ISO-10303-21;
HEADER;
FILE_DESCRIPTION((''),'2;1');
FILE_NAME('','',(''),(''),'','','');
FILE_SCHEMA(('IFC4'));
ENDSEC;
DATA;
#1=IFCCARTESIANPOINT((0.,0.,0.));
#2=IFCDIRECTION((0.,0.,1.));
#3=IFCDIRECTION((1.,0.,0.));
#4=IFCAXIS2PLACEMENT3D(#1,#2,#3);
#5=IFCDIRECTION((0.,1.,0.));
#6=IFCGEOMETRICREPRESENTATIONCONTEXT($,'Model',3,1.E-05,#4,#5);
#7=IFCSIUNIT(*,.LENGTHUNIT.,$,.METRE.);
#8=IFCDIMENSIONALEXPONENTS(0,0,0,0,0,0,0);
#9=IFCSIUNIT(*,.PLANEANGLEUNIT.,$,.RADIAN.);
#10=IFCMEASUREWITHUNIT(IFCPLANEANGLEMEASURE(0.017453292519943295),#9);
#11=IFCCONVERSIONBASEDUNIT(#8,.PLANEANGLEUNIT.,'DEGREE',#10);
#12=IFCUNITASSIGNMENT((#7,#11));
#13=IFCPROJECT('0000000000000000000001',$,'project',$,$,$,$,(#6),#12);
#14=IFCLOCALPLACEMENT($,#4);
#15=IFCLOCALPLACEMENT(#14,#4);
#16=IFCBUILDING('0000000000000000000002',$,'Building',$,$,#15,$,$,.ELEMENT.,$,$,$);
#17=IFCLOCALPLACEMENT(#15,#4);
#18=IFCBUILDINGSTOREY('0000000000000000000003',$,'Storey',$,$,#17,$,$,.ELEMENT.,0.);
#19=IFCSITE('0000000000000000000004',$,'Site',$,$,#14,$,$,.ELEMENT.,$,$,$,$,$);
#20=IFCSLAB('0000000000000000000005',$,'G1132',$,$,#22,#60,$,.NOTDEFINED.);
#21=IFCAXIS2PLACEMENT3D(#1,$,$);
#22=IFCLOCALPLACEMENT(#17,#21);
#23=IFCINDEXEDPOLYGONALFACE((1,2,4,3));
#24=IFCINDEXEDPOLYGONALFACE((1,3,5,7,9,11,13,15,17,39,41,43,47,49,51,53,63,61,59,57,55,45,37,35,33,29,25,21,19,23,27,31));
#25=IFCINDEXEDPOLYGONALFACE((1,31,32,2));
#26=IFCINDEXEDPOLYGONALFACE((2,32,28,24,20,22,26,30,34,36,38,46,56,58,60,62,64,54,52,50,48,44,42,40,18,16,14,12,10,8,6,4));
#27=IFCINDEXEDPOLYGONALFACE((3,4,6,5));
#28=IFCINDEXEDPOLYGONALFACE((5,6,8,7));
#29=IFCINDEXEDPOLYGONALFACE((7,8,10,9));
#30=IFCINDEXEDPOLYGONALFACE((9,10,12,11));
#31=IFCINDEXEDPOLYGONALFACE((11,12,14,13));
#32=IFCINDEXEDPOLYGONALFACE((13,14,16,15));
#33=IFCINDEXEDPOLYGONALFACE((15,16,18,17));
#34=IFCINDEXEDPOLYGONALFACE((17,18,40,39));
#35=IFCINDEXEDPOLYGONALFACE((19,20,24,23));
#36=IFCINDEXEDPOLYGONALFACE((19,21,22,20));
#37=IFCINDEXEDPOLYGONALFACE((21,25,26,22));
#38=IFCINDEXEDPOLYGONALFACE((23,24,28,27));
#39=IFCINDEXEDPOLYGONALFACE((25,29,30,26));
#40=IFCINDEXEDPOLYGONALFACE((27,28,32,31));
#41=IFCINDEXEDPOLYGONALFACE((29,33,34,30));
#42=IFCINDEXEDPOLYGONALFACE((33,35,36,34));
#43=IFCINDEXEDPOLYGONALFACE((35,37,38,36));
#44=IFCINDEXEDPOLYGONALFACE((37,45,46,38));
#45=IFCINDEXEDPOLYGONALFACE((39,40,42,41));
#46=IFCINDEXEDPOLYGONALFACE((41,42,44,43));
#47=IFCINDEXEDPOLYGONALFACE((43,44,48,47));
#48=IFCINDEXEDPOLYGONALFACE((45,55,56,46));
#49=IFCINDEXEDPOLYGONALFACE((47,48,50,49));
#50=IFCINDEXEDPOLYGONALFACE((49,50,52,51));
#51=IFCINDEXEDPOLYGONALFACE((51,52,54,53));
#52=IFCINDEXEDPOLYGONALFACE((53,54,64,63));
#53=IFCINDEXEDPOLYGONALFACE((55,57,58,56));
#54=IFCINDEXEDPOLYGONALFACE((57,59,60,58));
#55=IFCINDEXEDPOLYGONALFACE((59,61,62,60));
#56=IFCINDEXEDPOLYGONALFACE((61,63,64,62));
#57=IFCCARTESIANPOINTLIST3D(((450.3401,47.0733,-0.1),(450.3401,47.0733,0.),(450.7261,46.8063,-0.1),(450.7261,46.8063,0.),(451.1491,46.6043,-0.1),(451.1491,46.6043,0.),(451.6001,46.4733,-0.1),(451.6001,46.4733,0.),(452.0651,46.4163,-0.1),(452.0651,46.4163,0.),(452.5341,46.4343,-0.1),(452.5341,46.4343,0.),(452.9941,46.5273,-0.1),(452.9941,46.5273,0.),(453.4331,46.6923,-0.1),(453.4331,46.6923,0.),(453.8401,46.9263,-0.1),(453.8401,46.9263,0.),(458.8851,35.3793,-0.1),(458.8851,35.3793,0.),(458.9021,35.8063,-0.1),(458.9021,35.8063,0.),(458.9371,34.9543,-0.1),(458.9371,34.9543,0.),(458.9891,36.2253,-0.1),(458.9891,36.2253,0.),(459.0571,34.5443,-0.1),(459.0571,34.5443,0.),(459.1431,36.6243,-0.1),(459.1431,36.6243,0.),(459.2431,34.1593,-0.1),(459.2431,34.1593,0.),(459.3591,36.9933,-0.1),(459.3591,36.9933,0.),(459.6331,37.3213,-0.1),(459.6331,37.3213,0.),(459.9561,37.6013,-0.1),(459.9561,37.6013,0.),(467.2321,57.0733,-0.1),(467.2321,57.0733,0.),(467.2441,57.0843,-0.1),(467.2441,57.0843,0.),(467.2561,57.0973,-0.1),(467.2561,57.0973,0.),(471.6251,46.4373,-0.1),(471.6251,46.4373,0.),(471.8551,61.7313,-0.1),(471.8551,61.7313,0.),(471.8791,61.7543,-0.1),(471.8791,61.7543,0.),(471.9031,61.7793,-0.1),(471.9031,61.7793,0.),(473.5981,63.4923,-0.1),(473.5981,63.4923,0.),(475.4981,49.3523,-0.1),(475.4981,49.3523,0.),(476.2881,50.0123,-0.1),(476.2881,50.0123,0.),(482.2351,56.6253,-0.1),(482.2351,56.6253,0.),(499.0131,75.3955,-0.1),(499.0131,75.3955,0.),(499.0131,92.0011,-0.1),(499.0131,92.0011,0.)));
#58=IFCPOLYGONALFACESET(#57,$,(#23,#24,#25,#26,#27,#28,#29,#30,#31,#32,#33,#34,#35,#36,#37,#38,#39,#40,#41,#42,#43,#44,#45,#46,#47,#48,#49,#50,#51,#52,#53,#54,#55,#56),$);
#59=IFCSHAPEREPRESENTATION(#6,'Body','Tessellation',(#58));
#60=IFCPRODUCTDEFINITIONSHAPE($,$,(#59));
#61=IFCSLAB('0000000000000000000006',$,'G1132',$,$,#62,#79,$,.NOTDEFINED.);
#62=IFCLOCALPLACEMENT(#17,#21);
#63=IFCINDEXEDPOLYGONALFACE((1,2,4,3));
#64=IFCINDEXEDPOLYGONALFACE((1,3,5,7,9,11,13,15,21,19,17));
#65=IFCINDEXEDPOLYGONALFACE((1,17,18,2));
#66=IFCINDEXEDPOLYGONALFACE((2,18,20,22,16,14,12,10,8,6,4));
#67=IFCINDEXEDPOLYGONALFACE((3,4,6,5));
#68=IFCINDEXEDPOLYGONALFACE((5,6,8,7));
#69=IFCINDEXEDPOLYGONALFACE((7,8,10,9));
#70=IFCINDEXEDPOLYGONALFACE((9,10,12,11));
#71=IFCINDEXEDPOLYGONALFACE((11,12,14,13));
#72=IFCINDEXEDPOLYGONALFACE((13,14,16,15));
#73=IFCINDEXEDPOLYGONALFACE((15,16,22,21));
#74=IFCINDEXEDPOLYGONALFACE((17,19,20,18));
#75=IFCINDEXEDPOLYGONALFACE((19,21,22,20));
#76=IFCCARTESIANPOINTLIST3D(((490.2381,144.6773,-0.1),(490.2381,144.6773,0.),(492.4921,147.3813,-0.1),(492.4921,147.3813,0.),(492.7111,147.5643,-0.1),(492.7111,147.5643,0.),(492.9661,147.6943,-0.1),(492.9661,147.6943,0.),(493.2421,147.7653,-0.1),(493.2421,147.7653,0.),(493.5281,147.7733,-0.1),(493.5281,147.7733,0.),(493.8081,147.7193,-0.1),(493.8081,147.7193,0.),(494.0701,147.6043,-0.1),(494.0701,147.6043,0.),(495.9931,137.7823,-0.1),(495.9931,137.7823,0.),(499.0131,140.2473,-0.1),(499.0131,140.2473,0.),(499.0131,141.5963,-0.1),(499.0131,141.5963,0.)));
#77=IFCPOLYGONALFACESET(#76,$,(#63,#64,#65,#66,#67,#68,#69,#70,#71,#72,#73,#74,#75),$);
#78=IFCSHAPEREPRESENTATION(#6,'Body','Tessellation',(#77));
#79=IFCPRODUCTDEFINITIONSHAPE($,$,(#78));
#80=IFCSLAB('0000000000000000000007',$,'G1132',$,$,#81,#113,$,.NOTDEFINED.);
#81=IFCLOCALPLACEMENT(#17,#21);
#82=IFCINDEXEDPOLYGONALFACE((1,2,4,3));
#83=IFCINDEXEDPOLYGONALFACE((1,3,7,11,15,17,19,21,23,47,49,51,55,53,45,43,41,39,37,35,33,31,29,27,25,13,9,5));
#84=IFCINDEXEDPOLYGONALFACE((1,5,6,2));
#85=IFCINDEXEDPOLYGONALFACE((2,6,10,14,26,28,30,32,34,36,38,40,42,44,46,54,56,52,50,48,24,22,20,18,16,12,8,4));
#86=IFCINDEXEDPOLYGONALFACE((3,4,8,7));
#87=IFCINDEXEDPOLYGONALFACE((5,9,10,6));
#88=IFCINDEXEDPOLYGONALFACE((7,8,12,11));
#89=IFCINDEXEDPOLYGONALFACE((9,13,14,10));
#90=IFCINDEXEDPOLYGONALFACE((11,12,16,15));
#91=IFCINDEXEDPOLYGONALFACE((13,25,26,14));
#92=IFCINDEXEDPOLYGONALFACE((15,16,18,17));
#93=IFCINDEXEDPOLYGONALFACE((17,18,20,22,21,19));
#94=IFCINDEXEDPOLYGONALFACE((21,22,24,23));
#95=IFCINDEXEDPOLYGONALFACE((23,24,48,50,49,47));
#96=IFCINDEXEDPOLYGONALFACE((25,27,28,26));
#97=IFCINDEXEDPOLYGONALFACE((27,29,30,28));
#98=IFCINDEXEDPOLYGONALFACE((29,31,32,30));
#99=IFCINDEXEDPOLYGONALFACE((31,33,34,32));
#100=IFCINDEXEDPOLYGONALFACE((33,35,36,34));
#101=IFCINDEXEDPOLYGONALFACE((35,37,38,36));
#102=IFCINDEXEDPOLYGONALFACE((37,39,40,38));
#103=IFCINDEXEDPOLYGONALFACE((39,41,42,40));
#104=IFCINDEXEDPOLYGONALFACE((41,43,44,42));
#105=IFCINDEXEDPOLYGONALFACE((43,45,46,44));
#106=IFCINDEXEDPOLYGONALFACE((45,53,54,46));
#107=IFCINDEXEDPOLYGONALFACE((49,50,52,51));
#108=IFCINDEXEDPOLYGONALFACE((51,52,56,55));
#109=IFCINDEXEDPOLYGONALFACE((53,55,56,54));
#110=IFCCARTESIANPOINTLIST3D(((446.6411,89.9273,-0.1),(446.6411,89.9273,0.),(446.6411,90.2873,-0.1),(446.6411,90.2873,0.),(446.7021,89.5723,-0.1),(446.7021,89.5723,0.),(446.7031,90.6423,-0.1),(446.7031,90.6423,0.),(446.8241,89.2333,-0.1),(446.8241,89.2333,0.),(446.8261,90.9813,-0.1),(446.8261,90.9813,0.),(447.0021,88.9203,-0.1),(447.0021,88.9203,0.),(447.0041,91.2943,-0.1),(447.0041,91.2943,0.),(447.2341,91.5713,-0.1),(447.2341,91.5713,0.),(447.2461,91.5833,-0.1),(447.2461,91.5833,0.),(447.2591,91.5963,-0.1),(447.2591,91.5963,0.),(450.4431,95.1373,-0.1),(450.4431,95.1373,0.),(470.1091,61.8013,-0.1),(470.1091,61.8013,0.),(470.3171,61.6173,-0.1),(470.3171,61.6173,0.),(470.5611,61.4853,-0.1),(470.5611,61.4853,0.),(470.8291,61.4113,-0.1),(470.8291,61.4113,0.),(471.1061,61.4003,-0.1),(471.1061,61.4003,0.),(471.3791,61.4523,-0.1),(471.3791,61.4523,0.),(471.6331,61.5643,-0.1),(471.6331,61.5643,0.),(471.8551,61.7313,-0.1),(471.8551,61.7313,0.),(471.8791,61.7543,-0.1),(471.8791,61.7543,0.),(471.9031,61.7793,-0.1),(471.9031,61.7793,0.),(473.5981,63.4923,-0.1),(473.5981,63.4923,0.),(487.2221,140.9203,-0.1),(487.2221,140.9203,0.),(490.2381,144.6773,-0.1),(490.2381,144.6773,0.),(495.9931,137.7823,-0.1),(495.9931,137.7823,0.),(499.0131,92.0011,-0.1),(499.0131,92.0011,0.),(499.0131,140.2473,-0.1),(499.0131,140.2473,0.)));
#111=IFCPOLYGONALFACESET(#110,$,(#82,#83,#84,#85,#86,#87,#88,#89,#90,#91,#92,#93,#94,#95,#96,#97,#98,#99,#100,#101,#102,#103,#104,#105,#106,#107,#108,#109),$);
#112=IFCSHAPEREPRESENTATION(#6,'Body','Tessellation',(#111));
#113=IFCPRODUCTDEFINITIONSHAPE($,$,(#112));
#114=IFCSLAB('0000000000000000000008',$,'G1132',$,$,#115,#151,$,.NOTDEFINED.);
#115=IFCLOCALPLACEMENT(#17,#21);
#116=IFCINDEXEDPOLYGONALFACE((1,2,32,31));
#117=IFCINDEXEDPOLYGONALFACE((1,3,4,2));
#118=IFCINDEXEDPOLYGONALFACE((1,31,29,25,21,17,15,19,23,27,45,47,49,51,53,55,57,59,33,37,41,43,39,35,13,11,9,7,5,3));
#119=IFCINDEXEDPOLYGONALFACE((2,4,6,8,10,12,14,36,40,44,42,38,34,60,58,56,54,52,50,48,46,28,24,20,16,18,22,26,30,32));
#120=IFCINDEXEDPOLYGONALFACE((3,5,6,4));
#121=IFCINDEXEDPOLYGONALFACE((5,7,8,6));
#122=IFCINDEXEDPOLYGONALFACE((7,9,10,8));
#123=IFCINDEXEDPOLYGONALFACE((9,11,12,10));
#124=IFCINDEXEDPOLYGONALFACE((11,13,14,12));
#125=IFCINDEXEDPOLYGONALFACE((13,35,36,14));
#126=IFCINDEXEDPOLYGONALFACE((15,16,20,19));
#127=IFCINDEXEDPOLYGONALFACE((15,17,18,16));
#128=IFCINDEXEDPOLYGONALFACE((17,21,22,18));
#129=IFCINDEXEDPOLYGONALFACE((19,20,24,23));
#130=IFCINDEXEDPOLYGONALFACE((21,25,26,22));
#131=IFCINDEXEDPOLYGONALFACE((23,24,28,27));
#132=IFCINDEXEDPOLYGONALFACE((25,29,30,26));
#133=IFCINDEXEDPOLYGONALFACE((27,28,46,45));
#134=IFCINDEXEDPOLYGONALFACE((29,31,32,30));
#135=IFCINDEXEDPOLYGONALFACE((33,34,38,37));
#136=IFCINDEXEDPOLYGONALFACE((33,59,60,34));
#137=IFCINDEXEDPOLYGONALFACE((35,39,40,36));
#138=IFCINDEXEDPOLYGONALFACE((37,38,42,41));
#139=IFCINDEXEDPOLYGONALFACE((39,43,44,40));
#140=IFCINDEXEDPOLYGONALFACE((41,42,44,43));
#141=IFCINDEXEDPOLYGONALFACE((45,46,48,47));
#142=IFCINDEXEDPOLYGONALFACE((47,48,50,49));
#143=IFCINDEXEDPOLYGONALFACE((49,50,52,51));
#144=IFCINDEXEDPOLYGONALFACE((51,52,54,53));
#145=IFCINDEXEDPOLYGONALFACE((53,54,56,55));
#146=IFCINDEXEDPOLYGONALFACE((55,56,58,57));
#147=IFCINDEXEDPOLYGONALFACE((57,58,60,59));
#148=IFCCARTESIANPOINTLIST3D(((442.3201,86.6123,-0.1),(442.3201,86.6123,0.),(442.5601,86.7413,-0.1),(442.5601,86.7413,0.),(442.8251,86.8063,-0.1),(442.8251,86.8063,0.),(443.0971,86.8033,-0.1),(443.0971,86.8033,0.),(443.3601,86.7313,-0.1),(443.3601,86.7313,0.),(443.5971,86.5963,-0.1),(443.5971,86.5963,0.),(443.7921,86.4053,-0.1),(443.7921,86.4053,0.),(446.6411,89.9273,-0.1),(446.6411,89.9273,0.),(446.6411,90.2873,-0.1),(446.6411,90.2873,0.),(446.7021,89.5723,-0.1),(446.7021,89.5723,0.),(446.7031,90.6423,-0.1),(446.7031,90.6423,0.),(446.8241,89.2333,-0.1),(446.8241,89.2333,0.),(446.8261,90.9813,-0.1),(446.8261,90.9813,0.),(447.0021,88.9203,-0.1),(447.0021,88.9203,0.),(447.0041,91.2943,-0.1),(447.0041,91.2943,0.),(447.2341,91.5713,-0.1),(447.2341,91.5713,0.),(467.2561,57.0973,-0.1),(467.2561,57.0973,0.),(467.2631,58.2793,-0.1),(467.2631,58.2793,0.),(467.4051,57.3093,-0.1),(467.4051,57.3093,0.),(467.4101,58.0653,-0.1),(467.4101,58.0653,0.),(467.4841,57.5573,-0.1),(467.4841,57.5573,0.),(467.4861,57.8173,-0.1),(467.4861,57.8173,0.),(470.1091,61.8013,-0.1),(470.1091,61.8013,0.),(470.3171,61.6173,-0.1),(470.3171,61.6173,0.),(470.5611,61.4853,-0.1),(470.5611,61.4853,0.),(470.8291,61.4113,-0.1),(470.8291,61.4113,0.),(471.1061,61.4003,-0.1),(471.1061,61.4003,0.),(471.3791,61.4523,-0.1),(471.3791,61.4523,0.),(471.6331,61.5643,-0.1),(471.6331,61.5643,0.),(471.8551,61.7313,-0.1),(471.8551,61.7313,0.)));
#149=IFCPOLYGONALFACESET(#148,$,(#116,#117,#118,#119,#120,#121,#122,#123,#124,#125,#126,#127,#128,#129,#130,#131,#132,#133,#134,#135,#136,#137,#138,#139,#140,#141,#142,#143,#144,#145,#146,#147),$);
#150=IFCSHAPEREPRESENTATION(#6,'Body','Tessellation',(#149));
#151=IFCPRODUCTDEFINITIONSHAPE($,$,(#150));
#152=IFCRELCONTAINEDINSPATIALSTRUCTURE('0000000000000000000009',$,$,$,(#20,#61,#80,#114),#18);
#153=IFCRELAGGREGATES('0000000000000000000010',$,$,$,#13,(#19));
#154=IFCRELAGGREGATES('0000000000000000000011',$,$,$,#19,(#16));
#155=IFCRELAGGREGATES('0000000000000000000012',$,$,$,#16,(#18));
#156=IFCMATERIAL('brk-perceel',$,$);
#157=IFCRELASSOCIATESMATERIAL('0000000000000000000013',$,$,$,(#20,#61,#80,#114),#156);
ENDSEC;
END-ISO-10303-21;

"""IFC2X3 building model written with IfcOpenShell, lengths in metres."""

from ifc_helpers import new_model, entity, si_unit, converted_unit, direction, frame, origin_with_axes, place, context, project, spatial, polyline, outline, extrude, material, element, save


model = new_model("IFC2X3")

# Units and contexts
model_context = context("Model", 3, precision=1e-05, world=origin_with_axes(), true_north=direction((0.0, 1.0, 0.0)))
ifc_project = project(units=[si_unit("LENGTHUNIT", "METRE"), converted_unit("PLANEANGLEUNIT", "DEGREE", entity("IfcPlaneAngleMeasure", 0.017453292519943295), si_unit("PLANEANGLEUNIT", "RADIAN"), dimensions=[0, 0, 0, 0, 0, 0, 0])], contexts=[model_context])

# Site, building, storey
site_placement = place(None, origin_with_axes())
site = spatial("IfcSite", under=ifc_project, at=site_placement, Name="Site", CompositionType="ELEMENT")
building_placement = place(site_placement, origin_with_axes())
building = spatial("IfcBuilding", under=site, at=building_placement, Name="Building", CompositionType="ELEMENT")
storey_placement = place(building_placement, origin_with_axes())
storey = spatial("IfcBuildingStorey", under=building, at=storey_placement, Name="Storey", CompositionType="ELEMENT", Elevation=0.0)

# Slabs
ifc_material = material(Name="brk-perceel")
slab_1_placement = place(storey_placement, frame((0.0, 0.0, -0.1), z_axis=(0.0, 0.0, 1.0), x_axis=(1.0, 0.0, 0.0)))
element("IfcSlab", 1, at=slab_1_placement, inside=storey, material=ifc_material, Name="G1132", PredefinedType="NOTDEFINED", context=model_context, shape_type="SweptSolid", body=[
    extrude(outline(polyline([(482.2351, 56.6253), (476.2881, 50.0123), (475.4981, 49.3523), (471.6251, 46.4373), (459.9561, 37.6013), (459.6331, 37.3213), (459.3591, 36.9933), (459.1431, 36.6243), (458.9891, 36.2253), (458.9021, 35.8063), (458.8851, 35.3793), (458.9371, 34.9543), (459.0571, 34.5443), (459.2431, 34.1593), (450.3401, 47.0733), (450.7261, 46.8063), (451.1491, 46.6043), (451.6001, 46.4733), (452.0651, 46.4163), (452.5341, 46.4343), (452.9941, 46.5273), (453.4331, 46.6923), (453.8401, 46.9263), (467.2321, 57.0733), (467.2441, 57.0843), (467.2561, 57.0973), (471.8551, 61.7313), (471.8791, 61.7543), (471.9031, 61.7793), (473.5981, 63.4923), (499.0131, 92.0011), (499.0131, 75.3955), (482.2351, 56.6253)])), origin_with_axes(), (0.0, 0.0, 1.0), 0.1),
])
slab_2_placement = place(storey_placement, frame((0.0, 0.0, -0.1), z_axis=(0.0, 0.0, 1.0), x_axis=(1.0, 0.0, 0.0)))
element("IfcSlab", 2, at=slab_2_placement, inside=storey, material=ifc_material, Name="G1132", PredefinedType="NOTDEFINED", context=model_context, shape_type="SweptSolid", body=[
    extrude(outline(polyline([(495.9931, 137.7823), (490.2381, 144.6773), (492.4921, 147.3813), (492.7111, 147.5643), (492.9661, 147.6943), (493.2421, 147.7653), (493.5281, 147.7733), (493.8081, 147.7193), (494.0701, 147.6043), (499.0131, 141.5963), (499.0131, 140.2473), (495.9931, 137.7823)])), origin_with_axes(), (0.0, 0.0, 1.0), 0.1),
])
slab_3_placement = place(storey_placement, frame((0.0, 0.0, -0.1), z_axis=(0.0, 0.0, 1.0), x_axis=(1.0, 0.0, 0.0)))
element("IfcSlab", 3, at=slab_3_placement, inside=storey, material=ifc_material, Name="G1132", PredefinedType="NOTDEFINED", context=model_context, shape_type="SweptSolid", body=[
    extrude(outline(polyline([(473.5981, 63.4923), (471.9031, 61.7793), (471.8791, 61.7543), (471.8551, 61.7313), (471.6331, 61.5643), (471.3791, 61.4523), (471.1061, 61.4003), (470.8291, 61.4113), (470.5611, 61.4853), (470.3171, 61.6173), (470.1091, 61.8013), (447.0021, 88.9203), (446.8241, 89.2333), (446.7021, 89.5723), (446.6411, 89.9273), (446.6411, 90.2873), (446.7031, 90.6423), (446.8261, 90.9813), (447.0041, 91.2943), (447.2341, 91.5713), (447.2461, 91.5833), (447.2591, 91.5963), (450.4431, 95.1373), (487.2221, 140.9203), (490.2381, 144.6773), (495.9931, 137.7823), (499.0131, 140.2473), (499.0131, 92.0011), (473.5981, 63.4923)])), origin_with_axes(), (0.0, 0.0, 1.0), 0.1),
])
slab_4_placement = place(storey_placement, frame((0.0, 0.0, -0.1), z_axis=(0.0, 0.0, 1.0), x_axis=(1.0, 0.0, 0.0)))
element("IfcSlab", 4, at=slab_4_placement, inside=storey, material=ifc_material, Name="G1132", PredefinedType="NOTDEFINED", context=model_context, shape_type="SweptSolid", body=[
    extrude(outline(polyline([(467.4051, 57.3093), (467.4841, 57.5573), (467.4861, 57.8173), (467.4101, 58.0653), (467.2631, 58.2793), (443.7921, 86.4053), (443.5971, 86.5963), (443.3601, 86.7313), (443.0971, 86.8033), (442.8251, 86.8063), (442.5601, 86.7413), (442.3201, 86.6123), (447.2341, 91.5713), (447.0041, 91.2943), (446.8261, 90.9813), (446.7031, 90.6423), (446.6411, 90.2873), (446.6411, 89.9273), (446.7021, 89.5723), (446.8241, 89.2333), (447.0021, 88.9203), (470.1091, 61.8013), (470.3171, 61.6173), (470.5611, 61.4853), (470.8291, 61.4113), (471.1061, 61.4003), (471.3791, 61.4523), (471.6331, 61.5643), (471.8551, 61.7313), (467.2561, 57.0973), (467.4051, 57.3093)])), origin_with_axes(), (0.0, 0.0, 1.0), 0.1),
])

save(model, "model.ifc")
